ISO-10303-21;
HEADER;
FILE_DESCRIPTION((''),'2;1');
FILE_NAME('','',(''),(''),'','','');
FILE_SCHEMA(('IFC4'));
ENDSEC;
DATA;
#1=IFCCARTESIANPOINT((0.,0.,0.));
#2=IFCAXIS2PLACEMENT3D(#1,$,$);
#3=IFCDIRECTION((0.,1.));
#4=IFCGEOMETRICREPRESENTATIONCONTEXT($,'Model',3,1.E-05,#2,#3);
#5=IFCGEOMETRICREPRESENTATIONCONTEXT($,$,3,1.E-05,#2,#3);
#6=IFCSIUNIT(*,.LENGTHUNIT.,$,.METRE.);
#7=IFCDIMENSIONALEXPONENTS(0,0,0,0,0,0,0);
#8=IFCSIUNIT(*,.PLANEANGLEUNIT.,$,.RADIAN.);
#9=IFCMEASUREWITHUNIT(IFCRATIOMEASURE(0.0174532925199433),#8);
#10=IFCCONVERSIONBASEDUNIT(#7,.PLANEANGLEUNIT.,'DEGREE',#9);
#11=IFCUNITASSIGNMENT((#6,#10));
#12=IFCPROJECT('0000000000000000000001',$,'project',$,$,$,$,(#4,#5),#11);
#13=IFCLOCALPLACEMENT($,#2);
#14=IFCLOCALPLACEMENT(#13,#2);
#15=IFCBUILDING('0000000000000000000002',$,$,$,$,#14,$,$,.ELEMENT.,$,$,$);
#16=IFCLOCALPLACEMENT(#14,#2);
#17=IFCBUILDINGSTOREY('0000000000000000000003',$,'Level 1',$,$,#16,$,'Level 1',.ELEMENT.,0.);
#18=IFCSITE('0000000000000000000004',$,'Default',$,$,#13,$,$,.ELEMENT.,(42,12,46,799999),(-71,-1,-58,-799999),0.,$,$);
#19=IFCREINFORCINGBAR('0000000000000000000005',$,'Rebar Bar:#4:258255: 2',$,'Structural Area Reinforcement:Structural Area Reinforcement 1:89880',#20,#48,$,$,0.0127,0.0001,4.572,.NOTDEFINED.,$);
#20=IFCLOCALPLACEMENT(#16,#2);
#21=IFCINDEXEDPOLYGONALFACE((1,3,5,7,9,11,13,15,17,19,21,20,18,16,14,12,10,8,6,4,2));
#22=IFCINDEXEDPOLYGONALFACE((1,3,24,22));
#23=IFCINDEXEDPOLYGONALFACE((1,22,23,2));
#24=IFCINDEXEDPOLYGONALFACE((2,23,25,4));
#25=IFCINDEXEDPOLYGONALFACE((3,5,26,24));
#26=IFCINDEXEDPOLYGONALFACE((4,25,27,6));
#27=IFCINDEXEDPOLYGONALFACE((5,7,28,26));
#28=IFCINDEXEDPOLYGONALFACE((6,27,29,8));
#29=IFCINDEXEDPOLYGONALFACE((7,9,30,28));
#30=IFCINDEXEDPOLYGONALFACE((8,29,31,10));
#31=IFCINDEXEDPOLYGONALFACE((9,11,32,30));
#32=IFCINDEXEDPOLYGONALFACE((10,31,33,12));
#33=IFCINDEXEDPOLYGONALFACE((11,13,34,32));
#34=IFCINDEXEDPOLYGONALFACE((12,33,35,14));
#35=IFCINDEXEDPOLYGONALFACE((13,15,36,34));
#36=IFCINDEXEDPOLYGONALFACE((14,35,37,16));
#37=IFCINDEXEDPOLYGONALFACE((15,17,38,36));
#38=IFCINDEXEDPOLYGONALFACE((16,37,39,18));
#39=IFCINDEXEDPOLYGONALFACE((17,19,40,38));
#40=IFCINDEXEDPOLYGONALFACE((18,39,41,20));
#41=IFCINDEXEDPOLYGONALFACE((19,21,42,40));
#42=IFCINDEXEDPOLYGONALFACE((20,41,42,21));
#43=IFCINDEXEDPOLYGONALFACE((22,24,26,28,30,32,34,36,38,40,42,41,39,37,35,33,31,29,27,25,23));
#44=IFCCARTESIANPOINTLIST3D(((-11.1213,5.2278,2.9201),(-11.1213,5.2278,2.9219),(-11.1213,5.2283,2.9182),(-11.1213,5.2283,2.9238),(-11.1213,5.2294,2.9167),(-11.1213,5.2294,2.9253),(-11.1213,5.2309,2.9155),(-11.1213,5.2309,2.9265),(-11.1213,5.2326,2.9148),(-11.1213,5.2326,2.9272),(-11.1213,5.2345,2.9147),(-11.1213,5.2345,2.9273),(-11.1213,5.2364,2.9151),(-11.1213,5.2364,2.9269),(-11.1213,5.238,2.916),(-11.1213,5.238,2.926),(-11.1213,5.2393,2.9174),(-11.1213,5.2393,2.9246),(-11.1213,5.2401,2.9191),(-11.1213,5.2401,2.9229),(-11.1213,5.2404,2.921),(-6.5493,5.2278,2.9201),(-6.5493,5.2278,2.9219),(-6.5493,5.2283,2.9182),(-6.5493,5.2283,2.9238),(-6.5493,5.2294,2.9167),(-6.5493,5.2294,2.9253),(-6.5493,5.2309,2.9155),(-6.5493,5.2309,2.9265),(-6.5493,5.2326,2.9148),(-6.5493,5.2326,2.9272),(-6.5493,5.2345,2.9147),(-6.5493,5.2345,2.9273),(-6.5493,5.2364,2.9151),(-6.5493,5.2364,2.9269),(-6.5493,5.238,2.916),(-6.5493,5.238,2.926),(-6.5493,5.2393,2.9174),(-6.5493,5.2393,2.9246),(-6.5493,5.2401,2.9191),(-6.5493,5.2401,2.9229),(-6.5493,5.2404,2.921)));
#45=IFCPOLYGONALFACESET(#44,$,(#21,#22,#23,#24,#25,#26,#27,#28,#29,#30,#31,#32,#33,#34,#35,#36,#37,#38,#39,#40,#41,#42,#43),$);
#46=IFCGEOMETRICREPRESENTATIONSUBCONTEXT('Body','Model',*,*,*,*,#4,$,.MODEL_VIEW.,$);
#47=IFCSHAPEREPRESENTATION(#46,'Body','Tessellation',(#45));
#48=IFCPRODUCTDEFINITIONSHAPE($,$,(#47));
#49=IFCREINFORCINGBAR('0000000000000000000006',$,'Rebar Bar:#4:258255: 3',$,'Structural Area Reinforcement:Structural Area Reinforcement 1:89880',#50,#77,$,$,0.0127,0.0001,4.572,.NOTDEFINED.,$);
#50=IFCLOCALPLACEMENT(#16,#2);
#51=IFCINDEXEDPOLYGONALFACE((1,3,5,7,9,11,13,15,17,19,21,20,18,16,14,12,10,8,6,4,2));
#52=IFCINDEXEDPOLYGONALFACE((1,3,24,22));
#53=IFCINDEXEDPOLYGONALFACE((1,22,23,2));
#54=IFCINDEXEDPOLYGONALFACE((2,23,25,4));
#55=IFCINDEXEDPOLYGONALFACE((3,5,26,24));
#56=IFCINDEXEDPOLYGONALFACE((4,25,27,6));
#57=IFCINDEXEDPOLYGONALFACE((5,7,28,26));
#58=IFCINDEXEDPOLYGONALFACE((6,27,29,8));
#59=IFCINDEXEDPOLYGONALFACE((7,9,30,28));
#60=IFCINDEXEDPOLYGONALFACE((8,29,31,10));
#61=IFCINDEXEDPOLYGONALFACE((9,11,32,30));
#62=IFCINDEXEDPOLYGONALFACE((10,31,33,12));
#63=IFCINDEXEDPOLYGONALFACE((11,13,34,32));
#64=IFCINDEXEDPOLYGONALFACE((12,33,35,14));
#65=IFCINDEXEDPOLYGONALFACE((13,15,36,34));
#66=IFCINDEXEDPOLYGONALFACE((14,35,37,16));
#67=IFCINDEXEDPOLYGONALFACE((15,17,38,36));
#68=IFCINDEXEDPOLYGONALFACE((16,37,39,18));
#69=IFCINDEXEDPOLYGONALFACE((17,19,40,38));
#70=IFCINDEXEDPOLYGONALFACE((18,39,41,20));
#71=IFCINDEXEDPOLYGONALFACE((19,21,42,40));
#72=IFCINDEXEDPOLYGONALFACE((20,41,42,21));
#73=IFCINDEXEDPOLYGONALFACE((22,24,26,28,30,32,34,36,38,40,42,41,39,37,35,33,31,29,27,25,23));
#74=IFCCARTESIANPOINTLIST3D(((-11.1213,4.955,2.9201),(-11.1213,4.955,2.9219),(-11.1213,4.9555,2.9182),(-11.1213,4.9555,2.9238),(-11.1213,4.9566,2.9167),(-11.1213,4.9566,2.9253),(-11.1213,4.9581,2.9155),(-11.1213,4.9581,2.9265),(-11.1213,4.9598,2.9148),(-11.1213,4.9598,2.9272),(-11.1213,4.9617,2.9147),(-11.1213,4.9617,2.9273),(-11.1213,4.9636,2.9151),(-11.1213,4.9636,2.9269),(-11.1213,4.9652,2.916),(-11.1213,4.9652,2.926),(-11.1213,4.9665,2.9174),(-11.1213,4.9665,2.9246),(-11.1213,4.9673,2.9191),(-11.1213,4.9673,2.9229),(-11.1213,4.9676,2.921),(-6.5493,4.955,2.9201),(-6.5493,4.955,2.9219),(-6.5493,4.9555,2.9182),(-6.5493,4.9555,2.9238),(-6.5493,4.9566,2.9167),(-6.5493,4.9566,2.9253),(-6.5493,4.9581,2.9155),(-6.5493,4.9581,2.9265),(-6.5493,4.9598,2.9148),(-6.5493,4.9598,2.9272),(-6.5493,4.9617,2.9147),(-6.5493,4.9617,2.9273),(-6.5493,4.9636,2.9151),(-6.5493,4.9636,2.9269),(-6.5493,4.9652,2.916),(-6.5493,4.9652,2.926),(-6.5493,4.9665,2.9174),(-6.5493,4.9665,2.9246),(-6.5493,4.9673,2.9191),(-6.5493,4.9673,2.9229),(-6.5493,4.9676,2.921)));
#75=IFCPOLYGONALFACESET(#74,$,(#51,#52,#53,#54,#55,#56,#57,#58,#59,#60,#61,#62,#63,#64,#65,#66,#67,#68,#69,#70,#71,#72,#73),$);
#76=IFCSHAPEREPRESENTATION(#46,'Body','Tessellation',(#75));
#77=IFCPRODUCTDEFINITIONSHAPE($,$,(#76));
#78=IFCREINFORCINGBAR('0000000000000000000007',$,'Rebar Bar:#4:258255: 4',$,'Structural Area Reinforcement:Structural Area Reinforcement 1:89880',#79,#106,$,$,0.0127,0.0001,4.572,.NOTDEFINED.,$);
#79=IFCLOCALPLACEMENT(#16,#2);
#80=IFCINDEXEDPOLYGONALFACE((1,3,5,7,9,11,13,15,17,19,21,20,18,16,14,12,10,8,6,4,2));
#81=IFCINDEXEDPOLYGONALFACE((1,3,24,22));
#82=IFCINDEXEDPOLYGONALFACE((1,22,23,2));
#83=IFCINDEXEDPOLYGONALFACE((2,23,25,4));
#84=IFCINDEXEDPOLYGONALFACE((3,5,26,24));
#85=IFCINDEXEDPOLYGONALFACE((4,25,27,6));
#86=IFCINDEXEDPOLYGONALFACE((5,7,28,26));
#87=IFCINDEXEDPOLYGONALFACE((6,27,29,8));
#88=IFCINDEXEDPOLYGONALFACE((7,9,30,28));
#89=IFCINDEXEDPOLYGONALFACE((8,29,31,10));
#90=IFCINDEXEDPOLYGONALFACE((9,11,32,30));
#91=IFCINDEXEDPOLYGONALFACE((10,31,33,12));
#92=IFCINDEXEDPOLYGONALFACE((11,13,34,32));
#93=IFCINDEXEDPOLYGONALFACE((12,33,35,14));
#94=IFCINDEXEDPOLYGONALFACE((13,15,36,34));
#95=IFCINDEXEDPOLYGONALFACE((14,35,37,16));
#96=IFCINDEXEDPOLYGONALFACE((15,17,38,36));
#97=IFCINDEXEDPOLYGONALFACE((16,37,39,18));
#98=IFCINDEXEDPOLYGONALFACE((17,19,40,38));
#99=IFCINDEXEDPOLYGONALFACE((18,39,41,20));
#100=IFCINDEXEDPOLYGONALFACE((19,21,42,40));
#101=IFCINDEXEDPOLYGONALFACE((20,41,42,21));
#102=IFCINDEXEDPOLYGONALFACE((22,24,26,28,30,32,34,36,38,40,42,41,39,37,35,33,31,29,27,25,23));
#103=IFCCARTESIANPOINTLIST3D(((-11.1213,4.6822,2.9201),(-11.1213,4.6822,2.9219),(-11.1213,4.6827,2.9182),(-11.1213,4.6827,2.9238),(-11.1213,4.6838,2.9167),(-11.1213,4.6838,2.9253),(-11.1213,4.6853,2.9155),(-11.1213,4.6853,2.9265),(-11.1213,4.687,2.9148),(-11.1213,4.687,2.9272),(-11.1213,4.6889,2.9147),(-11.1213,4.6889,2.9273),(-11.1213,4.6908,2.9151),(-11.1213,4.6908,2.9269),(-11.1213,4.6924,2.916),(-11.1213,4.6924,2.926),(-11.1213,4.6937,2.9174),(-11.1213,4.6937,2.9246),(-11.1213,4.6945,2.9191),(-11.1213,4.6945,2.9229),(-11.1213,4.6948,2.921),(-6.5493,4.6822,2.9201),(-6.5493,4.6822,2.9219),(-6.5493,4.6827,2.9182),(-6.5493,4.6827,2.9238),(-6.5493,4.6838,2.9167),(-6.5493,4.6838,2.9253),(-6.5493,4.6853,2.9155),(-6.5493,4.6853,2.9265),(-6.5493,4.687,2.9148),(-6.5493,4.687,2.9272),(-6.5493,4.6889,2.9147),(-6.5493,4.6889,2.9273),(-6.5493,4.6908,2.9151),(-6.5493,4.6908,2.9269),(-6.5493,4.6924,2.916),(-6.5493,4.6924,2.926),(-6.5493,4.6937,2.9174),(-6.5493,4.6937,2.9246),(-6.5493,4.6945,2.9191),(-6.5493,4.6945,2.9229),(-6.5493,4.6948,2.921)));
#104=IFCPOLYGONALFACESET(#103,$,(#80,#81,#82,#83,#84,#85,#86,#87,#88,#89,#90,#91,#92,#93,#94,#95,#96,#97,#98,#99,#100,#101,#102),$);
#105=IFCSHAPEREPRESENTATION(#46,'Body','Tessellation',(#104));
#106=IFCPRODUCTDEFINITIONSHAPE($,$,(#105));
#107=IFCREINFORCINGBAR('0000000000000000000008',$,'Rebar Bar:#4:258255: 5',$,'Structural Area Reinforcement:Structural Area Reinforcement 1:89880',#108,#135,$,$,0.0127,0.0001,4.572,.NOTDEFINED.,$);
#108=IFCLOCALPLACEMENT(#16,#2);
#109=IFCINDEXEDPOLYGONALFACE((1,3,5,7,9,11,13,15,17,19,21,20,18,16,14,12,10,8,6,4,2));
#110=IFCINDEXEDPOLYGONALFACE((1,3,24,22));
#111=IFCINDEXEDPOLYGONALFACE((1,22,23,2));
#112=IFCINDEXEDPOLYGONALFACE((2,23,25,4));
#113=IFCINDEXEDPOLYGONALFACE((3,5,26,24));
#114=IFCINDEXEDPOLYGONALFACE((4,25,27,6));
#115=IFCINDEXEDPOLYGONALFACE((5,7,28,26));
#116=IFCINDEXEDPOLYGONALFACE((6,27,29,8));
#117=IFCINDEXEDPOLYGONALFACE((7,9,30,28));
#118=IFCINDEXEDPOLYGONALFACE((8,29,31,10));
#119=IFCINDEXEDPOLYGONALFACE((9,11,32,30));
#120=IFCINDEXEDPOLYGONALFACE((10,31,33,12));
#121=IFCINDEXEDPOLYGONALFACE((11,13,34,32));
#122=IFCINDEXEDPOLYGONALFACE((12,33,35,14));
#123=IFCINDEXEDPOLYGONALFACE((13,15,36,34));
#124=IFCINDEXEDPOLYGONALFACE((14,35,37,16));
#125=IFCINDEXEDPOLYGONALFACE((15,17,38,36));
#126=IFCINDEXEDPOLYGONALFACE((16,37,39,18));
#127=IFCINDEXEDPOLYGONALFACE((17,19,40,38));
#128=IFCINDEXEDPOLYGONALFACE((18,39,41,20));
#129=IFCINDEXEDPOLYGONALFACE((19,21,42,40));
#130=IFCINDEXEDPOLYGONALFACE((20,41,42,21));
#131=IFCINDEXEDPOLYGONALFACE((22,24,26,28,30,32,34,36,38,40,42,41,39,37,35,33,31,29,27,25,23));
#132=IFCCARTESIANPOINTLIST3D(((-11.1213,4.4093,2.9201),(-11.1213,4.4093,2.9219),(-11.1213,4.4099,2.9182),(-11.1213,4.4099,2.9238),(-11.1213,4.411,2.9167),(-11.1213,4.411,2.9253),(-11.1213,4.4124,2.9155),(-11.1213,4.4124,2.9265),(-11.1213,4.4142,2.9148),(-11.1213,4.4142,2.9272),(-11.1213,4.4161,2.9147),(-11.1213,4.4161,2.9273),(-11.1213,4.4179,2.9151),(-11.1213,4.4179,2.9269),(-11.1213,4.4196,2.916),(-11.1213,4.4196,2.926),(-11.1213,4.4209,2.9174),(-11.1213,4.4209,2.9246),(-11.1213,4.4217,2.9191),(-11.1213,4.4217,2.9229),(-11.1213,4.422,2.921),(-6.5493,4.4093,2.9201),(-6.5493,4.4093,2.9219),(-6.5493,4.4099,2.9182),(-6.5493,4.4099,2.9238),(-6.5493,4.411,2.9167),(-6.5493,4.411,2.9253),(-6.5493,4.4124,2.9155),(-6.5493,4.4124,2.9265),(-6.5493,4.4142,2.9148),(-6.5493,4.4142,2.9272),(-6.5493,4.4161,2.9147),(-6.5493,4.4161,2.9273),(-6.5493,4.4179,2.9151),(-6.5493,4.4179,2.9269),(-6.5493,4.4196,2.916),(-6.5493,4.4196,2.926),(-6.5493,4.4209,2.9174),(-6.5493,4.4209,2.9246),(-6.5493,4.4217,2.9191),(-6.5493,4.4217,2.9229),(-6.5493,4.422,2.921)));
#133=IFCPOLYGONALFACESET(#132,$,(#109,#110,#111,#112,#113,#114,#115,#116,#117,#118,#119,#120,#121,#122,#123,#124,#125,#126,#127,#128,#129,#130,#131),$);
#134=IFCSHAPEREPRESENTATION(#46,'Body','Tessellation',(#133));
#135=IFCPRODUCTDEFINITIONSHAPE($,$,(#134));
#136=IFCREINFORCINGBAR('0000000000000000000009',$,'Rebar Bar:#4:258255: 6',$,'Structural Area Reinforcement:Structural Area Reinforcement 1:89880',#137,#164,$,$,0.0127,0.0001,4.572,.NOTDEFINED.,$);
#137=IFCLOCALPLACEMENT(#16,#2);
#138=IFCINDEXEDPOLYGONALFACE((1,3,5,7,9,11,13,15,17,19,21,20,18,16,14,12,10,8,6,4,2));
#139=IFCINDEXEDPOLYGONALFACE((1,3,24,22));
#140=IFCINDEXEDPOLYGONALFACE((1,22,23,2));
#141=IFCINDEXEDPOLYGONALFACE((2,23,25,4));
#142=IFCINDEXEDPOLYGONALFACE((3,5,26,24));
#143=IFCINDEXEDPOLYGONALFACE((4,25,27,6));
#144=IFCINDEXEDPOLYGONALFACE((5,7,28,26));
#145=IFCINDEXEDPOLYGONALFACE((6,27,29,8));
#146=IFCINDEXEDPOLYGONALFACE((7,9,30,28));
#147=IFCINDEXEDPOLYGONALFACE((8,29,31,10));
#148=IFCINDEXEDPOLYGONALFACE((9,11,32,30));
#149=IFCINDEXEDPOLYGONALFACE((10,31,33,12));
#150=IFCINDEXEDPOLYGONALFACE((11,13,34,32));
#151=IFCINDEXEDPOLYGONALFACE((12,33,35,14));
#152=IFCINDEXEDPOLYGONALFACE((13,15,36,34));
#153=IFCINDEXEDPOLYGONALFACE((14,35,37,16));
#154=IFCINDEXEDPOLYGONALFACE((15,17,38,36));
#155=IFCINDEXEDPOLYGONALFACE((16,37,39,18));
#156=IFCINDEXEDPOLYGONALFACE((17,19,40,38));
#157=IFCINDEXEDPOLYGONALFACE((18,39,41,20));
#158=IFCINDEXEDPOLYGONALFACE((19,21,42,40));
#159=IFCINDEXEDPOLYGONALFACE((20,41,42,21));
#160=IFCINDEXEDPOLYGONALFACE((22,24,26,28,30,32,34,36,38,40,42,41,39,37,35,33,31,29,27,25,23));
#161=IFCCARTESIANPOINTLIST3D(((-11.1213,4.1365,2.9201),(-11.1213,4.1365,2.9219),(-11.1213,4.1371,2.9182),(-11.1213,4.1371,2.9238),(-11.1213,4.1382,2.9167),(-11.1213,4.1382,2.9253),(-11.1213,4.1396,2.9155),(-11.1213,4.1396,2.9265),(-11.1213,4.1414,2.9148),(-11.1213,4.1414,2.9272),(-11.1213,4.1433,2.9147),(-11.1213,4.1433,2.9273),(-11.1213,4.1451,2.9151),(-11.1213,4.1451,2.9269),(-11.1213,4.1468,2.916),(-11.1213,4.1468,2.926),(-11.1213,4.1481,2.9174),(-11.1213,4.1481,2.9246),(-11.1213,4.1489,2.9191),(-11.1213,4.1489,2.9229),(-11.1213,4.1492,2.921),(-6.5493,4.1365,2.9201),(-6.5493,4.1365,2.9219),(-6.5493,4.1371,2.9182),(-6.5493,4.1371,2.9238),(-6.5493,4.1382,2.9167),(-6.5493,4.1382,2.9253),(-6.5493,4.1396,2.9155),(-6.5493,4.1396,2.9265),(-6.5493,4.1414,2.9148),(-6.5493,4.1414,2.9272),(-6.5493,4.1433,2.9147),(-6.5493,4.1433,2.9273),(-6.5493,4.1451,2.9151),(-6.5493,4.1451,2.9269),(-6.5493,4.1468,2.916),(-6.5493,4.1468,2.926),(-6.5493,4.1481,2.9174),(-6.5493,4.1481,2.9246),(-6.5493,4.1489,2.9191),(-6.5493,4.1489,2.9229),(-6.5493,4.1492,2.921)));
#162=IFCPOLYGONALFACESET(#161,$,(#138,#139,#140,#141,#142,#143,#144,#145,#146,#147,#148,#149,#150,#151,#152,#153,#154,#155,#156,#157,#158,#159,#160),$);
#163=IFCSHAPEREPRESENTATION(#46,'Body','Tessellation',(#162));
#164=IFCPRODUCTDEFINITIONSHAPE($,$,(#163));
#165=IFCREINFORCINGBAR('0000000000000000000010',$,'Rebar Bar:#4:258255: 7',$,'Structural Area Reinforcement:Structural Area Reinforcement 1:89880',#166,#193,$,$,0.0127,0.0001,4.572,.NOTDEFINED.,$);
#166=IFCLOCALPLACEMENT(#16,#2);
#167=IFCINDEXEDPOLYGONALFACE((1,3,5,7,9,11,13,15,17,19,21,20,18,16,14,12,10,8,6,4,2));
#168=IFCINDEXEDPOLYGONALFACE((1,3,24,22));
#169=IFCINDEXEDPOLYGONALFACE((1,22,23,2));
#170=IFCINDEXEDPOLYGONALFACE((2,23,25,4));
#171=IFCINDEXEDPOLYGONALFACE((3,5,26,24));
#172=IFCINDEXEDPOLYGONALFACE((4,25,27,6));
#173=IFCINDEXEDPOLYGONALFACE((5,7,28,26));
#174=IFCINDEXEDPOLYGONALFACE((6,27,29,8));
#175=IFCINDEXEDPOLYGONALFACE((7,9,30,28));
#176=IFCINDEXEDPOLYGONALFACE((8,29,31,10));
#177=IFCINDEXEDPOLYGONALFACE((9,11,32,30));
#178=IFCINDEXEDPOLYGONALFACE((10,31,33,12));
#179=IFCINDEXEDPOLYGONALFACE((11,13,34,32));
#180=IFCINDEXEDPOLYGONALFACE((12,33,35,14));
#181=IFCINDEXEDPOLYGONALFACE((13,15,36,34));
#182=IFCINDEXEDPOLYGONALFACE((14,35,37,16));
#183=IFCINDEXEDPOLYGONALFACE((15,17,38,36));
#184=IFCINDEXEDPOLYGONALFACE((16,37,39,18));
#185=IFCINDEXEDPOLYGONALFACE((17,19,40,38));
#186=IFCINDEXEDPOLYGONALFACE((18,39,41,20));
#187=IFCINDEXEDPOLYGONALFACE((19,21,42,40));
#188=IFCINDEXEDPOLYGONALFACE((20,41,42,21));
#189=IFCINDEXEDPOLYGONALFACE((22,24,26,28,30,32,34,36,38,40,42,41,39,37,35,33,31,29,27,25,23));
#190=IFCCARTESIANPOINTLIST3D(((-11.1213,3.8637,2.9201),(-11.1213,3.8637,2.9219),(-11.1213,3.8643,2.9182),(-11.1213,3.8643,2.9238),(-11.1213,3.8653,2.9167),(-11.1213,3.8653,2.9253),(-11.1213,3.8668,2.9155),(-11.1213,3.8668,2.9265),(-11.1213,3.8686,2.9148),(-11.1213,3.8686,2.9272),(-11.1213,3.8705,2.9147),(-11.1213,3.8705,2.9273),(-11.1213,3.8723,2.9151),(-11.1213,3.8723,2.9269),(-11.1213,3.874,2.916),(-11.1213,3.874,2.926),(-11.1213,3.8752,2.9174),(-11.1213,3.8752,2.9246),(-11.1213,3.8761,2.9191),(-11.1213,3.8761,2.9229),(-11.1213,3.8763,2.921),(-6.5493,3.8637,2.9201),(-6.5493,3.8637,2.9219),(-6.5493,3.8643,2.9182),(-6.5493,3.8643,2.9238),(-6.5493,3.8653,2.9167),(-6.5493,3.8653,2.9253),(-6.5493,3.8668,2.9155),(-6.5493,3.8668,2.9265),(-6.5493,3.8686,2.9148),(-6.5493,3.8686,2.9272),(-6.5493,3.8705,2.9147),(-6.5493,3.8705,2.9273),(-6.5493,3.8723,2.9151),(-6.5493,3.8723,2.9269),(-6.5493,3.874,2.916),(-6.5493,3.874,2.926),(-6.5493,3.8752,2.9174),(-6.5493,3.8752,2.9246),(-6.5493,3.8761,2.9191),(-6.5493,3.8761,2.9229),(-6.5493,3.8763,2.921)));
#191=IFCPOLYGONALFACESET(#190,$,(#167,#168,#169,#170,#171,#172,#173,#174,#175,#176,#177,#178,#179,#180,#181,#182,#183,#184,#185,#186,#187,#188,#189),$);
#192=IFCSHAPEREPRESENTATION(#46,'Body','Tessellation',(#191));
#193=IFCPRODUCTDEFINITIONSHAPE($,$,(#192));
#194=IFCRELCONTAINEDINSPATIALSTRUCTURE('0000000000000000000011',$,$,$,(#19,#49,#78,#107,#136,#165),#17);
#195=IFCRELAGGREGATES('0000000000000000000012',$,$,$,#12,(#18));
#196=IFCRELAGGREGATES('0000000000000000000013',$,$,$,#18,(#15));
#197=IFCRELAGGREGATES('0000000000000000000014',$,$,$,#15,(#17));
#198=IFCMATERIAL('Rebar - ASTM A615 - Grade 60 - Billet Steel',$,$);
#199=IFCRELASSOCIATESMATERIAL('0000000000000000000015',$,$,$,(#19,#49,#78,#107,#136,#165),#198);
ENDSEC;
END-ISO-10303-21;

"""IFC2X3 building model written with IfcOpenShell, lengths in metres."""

from ifc_helpers import new_model, entity, si_unit, converted_unit, direction, origin, place, context, subcontext, project, spatial, material, element, save


model = new_model("IFC2X3")

# Units and contexts
model_context = context("Model", 3, precision=1e-05, world=origin(), true_north=direction((0.0, 1.0)))
context_of_model = context(None, 3, precision=1e-05, world=origin(), true_north=direction((0.0, 1.0)))
body_context = subcontext(model_context, "Body", "Model", "MODEL_VIEW")
ifc_project = project(units=[si_unit("LENGTHUNIT", "METRE"), converted_unit("PLANEANGLEUNIT", "DEGREE", entity("IfcRatioMeasure", 0.0174532925199433), si_unit("PLANEANGLEUNIT", "RADIAN"), dimensions=[0, 0, 0, 0, 0, 0, 0])], contexts=[model_context, context_of_model])

# Site, building, storey
site_placement = place(None, origin())
site = spatial("IfcSite", under=ifc_project, at=site_placement, Name="Default", CompositionType="ELEMENT", RefLatitude=(42, 12, 46, 799999), RefLongitude=(-71, -1, -58, -799999), RefElevation=0.0)
building_placement = place(site_placement, origin())
building = spatial("IfcBuilding", under=site, at=building_placement, CompositionType="ELEMENT")
storey_placement = place(building_placement, origin())
storey = spatial("IfcBuildingStorey", under=building, at=storey_placement, Name="Level 1", LongName="Level 1", CompositionType="ELEMENT", Elevation=0.0)

# Reinforcing bars
ifc_material_1 = material(Name="Rebar - ASTM A615 - Grade 60 - Billet Steel")
reinforcing_bar_1_placement = place(storey_placement, origin())
element("IfcReinforcingBar", 1, at=reinforcing_bar_1_placement, inside=storey, material=ifc_material_1, Name="Rebar Bar:#4:258255: 2", ObjectType="Structural Area Reinforcement:Structural Area Reinforcement 1:89880", BarLength=4.572, BarRole="NOTDEFINED", CrossSectionArea=0.0001, NominalDiameter=0.0127, context=body_context, shape_type="AdvancedSweptSolid", body=[
    entity("IfcSweptDiskSolid", entity("IfcCompositeCurve", [entity("IfcCompositeCurveSegment", "CONTINUOUS", True, entity("IfcPolyline", [entity("IfcCartesianPoint", [-11.1213, 5.2341, 2.921]), entity("IfcCartesianPoint", [-6.5493, 5.2341, 2.921])]))], False), 0.0063, None, 0.0, 1.0),
])
reinforcing_bar_2_placement = place(storey_placement, origin())
element("IfcReinforcingBar", 2, at=reinforcing_bar_2_placement, inside=storey, material=ifc_material_1, Name="Rebar Bar:#4:258255: 3", ObjectType="Structural Area Reinforcement:Structural Area Reinforcement 1:89880", BarLength=4.572, BarRole="NOTDEFINED", CrossSectionArea=0.0001, NominalDiameter=0.0127, context=body_context, shape_type="AdvancedSweptSolid", body=[
    entity("IfcSweptDiskSolid", entity("IfcCompositeCurve", [entity("IfcCompositeCurveSegment", "CONTINUOUS", True, entity("IfcPolyline", [entity("IfcCartesianPoint", [-11.1213, 4.9612, 2.921]), entity("IfcCartesianPoint", [-6.5493, 4.9612, 2.921])]))], False), 0.0063, None, 0.0, 1.0),
])
reinforcing_bar_3_placement = place(storey_placement, origin())
element("IfcReinforcingBar", 3, at=reinforcing_bar_3_placement, inside=storey, material=ifc_material_1, Name="Rebar Bar:#4:258255: 4", ObjectType="Structural Area Reinforcement:Structural Area Reinforcement 1:89880", BarLength=4.572, BarRole="NOTDEFINED", CrossSectionArea=0.0001, NominalDiameter=0.0127, context=body_context, shape_type="AdvancedSweptSolid", body=[
    entity("IfcSweptDiskSolid", entity("IfcCompositeCurve", [entity("IfcCompositeCurveSegment", "CONTINUOUS", True, entity("IfcPolyline", [entity("IfcCartesianPoint", [-11.1213, 4.6884, 2.921]), entity("IfcCartesianPoint", [-6.5493, 4.6884, 2.921])]))], False), 0.0063, None, 0.0, 1.0),
])
reinforcing_bar_4_placement = place(storey_placement, origin())
element("IfcReinforcingBar", 4, at=reinforcing_bar_4_placement, inside=storey, material=ifc_material_1, Name="Rebar Bar:#4:258255: 5", ObjectType="Structural Area Reinforcement:Structural Area Reinforcement 1:89880", BarLength=4.572, BarRole="NOTDEFINED", CrossSectionArea=0.0001, NominalDiameter=0.0127, context=body_context, shape_type="AdvancedSweptSolid", body=[
    entity("IfcSweptDiskSolid", entity("IfcCompositeCurve", [entity("IfcCompositeCurveSegment", "CONTINUOUS", True, entity("IfcPolyline", [entity("IfcCartesianPoint", [-11.1213, 4.4156, 2.921]), entity("IfcCartesianPoint", [-6.5493, 4.4156, 2.921])]))], False), 0.0063, None, 0.0, 1.0),
])
reinforcing_bar_5_placement = place(storey_placement, origin())
element("IfcReinforcingBar", 5, at=reinforcing_bar_5_placement, inside=storey, material=ifc_material_1, Name="Rebar Bar:#4:258255: 6", ObjectType="Structural Area Reinforcement:Structural Area Reinforcement 1:89880", BarLength=4.572, BarRole="NOTDEFINED", CrossSectionArea=0.0001, NominalDiameter=0.0127, context=body_context, shape_type="AdvancedSweptSolid", body=[
    entity("IfcSweptDiskSolid", entity("IfcCompositeCurve", [entity("IfcCompositeCurveSegment", "CONTINUOUS", True, entity("IfcPolyline", [entity("IfcCartesianPoint", [-11.1213, 4.1428, 2.921]), entity("IfcCartesianPoint", [-6.5493, 4.1428, 2.921])]))], False), 0.0063, None, 0.0, 1.0),
])
reinforcing_bar_6_placement = place(storey_placement, origin())
element("IfcReinforcingBar", 6, at=reinforcing_bar_6_placement, inside=storey, material=ifc_material_1, Name="Rebar Bar:#4:258255: 7", ObjectType="Structural Area Reinforcement:Structural Area Reinforcement 1:89880", BarLength=4.572, BarRole="NOTDEFINED", CrossSectionArea=0.0001, NominalDiameter=0.0127, context=body_context, shape_type="AdvancedSweptSolid", body=[
    entity("IfcSweptDiskSolid", entity("IfcCompositeCurve", [entity("IfcCompositeCurveSegment", "CONTINUOUS", True, entity("IfcPolyline", [entity("IfcCartesianPoint", [-11.1213, 3.87, 2.921]), entity("IfcCartesianPoint", [-6.5493, 3.87, 2.921])]))], False), 0.0063, None, 0.0, 1.0),
])

save(model, "model.ifc")
